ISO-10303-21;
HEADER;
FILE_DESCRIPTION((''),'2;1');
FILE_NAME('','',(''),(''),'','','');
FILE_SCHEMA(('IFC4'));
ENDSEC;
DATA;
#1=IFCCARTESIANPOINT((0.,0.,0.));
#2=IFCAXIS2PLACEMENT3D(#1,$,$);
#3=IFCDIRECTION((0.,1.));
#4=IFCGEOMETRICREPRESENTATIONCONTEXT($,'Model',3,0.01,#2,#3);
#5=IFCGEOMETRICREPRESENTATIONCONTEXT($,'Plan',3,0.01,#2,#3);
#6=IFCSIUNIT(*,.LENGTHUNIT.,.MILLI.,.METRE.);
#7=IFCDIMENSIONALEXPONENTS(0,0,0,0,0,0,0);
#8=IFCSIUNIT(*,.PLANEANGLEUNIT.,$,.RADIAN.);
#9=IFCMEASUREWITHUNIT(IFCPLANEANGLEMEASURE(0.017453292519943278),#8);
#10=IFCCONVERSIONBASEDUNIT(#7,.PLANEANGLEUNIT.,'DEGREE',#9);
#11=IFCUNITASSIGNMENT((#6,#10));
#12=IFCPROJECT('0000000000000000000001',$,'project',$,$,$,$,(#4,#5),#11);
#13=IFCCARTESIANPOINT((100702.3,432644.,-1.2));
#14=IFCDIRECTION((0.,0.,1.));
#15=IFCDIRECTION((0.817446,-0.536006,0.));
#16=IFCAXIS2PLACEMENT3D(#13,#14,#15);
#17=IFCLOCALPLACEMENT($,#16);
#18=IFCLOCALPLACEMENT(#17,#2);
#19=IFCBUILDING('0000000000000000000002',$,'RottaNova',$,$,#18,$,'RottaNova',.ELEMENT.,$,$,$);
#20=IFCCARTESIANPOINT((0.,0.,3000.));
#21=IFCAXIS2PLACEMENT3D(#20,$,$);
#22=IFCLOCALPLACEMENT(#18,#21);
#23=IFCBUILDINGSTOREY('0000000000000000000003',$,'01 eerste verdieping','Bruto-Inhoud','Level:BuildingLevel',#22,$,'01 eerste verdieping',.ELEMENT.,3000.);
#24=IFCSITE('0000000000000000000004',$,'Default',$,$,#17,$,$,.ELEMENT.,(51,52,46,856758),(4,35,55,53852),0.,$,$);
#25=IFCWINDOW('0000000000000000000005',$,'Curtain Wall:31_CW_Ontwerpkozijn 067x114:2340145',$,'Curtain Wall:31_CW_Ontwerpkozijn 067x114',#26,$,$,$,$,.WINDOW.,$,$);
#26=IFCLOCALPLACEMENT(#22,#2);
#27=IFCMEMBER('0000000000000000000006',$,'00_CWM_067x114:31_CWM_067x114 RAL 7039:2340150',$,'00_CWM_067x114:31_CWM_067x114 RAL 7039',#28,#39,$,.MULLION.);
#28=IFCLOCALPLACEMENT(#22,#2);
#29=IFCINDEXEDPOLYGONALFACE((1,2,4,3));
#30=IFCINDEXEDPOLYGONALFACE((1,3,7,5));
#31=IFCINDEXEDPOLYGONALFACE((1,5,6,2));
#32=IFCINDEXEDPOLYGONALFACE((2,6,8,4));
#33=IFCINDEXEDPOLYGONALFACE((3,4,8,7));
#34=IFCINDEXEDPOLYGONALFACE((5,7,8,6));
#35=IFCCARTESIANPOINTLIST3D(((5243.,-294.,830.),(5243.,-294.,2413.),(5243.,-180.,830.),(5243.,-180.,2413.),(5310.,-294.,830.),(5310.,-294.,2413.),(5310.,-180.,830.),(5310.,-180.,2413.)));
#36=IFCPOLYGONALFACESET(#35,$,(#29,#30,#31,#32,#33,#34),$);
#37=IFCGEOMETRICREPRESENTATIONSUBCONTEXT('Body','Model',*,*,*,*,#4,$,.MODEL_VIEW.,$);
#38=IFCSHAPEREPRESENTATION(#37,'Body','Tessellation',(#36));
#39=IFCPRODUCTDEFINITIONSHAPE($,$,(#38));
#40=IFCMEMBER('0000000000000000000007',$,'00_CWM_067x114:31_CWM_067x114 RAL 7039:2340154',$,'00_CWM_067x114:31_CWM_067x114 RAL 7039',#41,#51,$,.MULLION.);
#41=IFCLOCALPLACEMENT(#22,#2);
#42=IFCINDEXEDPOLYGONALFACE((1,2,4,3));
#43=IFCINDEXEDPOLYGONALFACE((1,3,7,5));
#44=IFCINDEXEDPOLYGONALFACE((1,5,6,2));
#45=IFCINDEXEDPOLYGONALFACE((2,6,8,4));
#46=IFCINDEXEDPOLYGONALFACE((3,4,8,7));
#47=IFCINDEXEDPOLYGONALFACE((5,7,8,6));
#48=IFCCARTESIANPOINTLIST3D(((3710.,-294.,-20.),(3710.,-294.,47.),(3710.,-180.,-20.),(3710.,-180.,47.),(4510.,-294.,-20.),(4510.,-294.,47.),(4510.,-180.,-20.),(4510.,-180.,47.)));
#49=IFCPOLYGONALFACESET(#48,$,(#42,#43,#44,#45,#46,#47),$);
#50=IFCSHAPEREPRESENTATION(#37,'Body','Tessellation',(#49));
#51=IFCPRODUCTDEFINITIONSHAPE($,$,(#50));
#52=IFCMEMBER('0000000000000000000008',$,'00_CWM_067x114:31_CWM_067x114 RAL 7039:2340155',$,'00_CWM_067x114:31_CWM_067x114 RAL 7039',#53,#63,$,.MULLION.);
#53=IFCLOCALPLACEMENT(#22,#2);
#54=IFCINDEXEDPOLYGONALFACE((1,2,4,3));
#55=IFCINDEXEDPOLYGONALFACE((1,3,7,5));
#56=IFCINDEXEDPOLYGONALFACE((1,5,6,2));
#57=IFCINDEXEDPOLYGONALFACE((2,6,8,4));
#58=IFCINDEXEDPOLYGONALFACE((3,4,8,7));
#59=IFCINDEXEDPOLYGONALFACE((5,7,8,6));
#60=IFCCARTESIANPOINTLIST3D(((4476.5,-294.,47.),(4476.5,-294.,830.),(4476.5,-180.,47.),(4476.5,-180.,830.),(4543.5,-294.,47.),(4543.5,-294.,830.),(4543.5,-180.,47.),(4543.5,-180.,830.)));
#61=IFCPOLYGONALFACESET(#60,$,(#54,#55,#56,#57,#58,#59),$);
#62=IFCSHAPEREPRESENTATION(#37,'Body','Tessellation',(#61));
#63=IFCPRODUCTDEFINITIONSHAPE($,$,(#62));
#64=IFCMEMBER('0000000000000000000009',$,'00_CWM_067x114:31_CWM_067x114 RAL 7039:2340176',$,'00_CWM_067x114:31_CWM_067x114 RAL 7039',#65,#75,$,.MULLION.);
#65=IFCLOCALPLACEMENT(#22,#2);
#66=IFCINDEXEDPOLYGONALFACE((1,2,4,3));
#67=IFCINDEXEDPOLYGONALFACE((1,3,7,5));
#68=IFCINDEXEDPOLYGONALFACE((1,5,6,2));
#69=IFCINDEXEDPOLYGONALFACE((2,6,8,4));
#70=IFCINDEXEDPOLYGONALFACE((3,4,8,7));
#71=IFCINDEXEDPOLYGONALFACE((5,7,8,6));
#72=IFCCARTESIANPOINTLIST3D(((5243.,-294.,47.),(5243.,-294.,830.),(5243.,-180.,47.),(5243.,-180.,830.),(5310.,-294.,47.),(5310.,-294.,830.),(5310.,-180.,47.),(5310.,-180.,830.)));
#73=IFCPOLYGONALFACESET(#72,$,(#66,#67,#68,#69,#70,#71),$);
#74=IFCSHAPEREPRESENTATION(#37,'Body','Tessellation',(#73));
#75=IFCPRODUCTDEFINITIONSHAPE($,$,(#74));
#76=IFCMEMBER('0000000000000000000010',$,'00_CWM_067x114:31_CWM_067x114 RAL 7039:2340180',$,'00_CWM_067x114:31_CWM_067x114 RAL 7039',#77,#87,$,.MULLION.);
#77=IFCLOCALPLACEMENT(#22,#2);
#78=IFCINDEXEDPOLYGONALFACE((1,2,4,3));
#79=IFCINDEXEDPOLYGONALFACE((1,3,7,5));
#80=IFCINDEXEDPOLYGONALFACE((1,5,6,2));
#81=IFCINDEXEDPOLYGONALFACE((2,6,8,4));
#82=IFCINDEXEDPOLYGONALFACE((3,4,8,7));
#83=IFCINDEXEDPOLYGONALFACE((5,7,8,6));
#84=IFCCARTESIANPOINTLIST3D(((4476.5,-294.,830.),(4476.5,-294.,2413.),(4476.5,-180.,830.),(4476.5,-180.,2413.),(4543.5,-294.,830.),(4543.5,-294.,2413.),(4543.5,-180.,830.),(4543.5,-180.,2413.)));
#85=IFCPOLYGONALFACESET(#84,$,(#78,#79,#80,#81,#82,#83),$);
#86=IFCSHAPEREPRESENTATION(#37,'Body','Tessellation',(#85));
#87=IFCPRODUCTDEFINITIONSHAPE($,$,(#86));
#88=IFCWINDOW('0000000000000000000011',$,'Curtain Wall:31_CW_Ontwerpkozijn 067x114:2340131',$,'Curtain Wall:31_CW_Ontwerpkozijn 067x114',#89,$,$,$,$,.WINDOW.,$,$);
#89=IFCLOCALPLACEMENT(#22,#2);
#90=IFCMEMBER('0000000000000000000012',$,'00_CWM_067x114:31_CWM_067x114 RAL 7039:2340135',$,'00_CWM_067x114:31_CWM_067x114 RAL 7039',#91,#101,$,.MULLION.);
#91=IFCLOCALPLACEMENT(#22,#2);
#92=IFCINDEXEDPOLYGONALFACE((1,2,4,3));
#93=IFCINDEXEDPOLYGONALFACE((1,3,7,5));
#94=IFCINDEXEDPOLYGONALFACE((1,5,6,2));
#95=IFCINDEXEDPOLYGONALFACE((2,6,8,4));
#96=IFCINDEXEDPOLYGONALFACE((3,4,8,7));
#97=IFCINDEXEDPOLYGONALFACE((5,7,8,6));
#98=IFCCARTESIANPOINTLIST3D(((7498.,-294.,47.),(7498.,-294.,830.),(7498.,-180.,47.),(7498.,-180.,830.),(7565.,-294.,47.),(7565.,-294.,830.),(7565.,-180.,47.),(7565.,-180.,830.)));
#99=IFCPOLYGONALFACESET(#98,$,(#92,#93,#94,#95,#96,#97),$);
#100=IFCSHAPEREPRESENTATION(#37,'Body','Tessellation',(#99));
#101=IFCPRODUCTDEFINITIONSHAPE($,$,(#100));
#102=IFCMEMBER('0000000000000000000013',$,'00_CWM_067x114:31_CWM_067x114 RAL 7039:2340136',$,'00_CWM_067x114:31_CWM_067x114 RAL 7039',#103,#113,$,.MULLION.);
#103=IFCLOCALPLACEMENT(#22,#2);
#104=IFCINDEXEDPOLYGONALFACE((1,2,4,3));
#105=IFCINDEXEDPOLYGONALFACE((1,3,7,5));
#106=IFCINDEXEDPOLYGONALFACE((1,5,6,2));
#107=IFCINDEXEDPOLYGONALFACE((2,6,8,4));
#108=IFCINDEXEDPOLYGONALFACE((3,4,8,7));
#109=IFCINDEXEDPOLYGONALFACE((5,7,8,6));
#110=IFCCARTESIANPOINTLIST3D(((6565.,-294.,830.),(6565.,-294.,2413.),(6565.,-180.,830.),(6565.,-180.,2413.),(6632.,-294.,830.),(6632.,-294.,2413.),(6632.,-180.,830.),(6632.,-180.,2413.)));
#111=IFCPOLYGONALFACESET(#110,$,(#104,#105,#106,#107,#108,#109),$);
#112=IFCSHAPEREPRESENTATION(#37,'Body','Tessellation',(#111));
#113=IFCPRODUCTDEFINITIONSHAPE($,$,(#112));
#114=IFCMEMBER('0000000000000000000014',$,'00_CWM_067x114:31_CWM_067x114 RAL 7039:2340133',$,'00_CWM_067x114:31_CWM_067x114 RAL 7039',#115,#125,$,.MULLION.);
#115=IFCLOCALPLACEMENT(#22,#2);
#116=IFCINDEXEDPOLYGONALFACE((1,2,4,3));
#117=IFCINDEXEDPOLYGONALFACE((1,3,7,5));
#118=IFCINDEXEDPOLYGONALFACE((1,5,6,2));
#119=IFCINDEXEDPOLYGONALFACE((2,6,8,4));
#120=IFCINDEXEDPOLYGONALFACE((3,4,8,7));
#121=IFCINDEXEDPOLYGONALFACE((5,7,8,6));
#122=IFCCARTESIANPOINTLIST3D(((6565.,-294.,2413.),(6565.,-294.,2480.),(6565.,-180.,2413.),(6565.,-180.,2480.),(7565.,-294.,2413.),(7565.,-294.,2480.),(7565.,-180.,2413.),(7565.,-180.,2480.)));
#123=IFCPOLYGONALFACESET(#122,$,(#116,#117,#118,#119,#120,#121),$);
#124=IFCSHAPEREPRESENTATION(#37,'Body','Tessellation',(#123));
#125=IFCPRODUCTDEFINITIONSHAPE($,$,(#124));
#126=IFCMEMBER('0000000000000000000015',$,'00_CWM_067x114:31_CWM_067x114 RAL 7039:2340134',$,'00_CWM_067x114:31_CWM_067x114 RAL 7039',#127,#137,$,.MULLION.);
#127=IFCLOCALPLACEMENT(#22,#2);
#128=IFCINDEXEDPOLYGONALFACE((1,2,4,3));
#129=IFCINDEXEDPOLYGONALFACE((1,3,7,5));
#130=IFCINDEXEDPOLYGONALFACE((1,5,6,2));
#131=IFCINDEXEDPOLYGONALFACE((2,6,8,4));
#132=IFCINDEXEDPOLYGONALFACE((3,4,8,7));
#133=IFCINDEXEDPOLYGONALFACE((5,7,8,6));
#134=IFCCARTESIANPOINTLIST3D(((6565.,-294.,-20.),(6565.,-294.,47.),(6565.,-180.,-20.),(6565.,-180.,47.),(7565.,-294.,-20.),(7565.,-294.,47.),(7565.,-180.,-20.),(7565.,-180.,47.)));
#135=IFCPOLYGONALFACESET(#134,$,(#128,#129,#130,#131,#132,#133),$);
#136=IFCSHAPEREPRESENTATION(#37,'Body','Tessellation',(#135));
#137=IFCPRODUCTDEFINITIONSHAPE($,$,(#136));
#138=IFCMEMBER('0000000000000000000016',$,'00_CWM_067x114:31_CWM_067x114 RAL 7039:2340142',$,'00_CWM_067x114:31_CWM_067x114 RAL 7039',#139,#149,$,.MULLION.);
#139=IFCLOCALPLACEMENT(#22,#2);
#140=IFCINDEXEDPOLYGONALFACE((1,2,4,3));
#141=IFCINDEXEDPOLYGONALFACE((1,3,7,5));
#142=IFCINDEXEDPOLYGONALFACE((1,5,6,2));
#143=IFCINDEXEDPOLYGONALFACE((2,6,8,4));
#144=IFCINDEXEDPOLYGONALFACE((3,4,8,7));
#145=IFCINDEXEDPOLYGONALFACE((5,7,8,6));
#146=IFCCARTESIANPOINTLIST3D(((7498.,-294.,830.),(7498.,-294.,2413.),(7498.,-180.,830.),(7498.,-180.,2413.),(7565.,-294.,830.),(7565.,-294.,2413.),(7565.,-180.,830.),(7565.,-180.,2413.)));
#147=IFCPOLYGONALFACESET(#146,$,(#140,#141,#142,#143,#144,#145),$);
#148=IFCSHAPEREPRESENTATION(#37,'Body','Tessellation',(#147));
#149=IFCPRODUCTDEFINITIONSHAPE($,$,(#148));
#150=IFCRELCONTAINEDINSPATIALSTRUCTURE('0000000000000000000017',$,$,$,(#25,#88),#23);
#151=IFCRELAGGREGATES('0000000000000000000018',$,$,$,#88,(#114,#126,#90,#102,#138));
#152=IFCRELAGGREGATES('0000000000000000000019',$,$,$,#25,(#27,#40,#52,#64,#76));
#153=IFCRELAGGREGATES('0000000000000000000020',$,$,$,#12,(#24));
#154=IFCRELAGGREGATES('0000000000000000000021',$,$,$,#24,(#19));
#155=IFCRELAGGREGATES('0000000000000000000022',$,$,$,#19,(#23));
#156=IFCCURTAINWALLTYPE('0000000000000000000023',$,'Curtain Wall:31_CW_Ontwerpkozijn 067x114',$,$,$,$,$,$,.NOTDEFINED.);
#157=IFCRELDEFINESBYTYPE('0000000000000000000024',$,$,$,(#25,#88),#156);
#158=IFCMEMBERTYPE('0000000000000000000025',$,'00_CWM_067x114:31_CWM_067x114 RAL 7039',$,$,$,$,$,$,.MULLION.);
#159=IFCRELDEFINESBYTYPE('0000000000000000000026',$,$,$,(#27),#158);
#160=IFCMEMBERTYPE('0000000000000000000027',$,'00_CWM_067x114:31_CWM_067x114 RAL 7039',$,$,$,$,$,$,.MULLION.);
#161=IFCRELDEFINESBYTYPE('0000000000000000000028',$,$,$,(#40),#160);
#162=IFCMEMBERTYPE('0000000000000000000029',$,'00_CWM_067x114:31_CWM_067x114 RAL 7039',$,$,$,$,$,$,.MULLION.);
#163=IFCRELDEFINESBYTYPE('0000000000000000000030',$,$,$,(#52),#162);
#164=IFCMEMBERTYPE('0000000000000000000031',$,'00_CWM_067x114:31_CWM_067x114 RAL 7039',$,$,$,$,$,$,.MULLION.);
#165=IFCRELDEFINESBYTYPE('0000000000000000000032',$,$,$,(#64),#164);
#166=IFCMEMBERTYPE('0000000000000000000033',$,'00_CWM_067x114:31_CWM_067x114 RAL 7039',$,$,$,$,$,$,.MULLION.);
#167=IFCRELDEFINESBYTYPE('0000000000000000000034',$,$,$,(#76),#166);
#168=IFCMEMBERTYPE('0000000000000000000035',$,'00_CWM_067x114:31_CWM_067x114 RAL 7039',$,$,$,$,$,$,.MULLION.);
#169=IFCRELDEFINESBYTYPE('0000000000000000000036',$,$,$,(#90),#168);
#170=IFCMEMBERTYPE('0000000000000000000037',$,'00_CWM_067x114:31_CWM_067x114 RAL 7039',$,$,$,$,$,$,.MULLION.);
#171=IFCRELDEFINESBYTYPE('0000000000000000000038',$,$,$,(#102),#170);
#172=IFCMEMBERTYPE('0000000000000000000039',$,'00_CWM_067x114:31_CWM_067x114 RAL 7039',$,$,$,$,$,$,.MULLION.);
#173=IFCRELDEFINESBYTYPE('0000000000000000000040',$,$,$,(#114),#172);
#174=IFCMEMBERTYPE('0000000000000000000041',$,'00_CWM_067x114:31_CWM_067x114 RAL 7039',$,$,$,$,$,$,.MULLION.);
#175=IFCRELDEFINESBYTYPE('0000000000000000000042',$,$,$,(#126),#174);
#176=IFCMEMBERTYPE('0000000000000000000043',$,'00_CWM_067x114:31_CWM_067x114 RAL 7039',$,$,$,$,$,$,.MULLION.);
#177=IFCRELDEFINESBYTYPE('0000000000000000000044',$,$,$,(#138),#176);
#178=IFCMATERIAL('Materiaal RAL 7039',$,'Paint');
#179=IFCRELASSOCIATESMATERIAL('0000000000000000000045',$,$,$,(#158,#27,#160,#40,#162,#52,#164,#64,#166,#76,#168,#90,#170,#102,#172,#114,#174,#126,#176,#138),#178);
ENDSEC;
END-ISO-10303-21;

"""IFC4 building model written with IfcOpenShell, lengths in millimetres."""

from ifc_helpers import new_model, entity, si_unit, converted_unit, direction, frame, origin, place, context, subcontext, project, spatial, indexed_curve, outline, extrude, source, transform, mapped, material, type_object, type_shapes, element, aggregate, save


model = new_model("IFC4")

# Units and contexts
model_context = context("Model", 3, precision=0.01, world=origin(), true_north=direction((0.0, 1.0)))
plan_context = context("Plan", 3, precision=0.01, world=origin(), true_north=direction((0.0, 1.0)))
body_context = subcontext(model_context, "Body", "Model", "MODEL_VIEW")
ifc_project = project(units=[si_unit("LENGTHUNIT", "METRE", prefix="MILLI"), converted_unit("PLANEANGLEUNIT", "DEGREE", entity("IfcPlaneAngleMeasure", 0.017453292519943278), si_unit("PLANEANGLEUNIT", "RADIAN"), dimensions=[0, 0, 0, 0, 0, 0, 0])], contexts=[model_context, plan_context])

# Site, building, storey
site_placement = place(None, frame((100702.3, 432644.0, -1.2), z_axis=(0.0, 0.0, 1.0), x_axis=(0.817446, -0.536006, 0.0)))
site = spatial("IfcSite", under=ifc_project, at=site_placement, Name="Default", CompositionType="ELEMENT", RefLatitude=(51, 52, 46, 856758), RefLongitude=(4, 35, 55, 53852), RefElevation=0.0)
building_placement = place(site_placement, origin())
building = spatial("IfcBuilding", under=site, at=building_placement, Name="RottaNova", LongName="RottaNova", CompositionType="ELEMENT")
storey_placement = place(building_placement, frame((0.0, 0.0, 3000.0)))
storey = spatial("IfcBuildingStorey", under=building, at=storey_placement, Name="01 eerste verdieping", Description="Bruto-Inhoud", ObjectType="Level:BuildingLevel", LongName="01 eerste verdieping", CompositionType="ELEMENT", Elevation=3000.0)

# Windows, members
curtain_wall_type = type_object("IfcCurtainWallType", Name="Curtain Wall:31_CW_Ontwerpkozijn 067x114", PredefinedType="NOTDEFINED")
window_1_placement = place(storey_placement, frame((0.0, 0.0, -3000.0)))
window_1 = element("IfcWindow", 1, at=window_1_placement, inside=storey, type_object=curtain_wall_type, Name="Curtain Wall:31_CW_Ontwerpkozijn 067x114:2340145", ObjectType="Curtain Wall:31_CW_Ontwerpkozijn 067x114", PredefinedType="WINDOW")
ifc_material_1 = material(Name="Materiaal RAL 7039", Category="Paint")
member_type_1 = type_object("IfcMemberType", Name="00_CWM_067x114:31_CWM_067x114 RAL 7039", PredefinedType="MULLION", material=ifc_material_1)
shared_shape_1 = source(origin(), body_context, "Body", "SweptSolid", [
    extrude(outline(indexed_curve([(-33.5, -57.0), (33.5, -57.0), (33.5, 57.0), (-33.5, 57.0), (-33.5, -57.0)], self_intersect=False)), frame((-33.5, -57.0, -1583.0), z_axis=(0.0, 0.0, 1.0), x_axis=(-1.0, 0.0, 0.0)), (0.0, 0.0, 1.0), 1583.0),
])
type_shapes(member_type_1, [shared_shape_1])
member_1_placement = place(window_1_placement, frame((5310.0, -180.0, 5413.0)))
member_1 = element("IfcMember", 2, at=member_1_placement, type_object=member_type_1, material=ifc_material_1, Name="00_CWM_067x114:31_CWM_067x114 RAL 7039:2340150", ObjectType="00_CWM_067x114:31_CWM_067x114 RAL 7039", PredefinedType="MULLION", context=body_context, shape_type="MappedRepresentation", body=[
    mapped(shared_shape_1, transform((0.0, 0.0, 0.0), scale=1.0)),
])
member_type_2 = type_object("IfcMemberType", Name="00_CWM_067x114:31_CWM_067x114 RAL 7039", PredefinedType="MULLION", material=ifc_material_1)
shared_shape_2 = source(origin(), body_context, "Body", "SweptSolid", [
    extrude(outline(indexed_curve([(-33.5, -57.0), (33.5, -57.0), (33.5, 57.0), (-33.5, 57.0), (-33.5, -57.0)], self_intersect=False)), frame((-33.5, -57.0, -800.0), z_axis=(0.0, 0.0, 1.0), x_axis=(-1.0, 0.0, 0.0)), (0.0, 0.0, 1.0), 800.0),
])
type_shapes(member_type_2, [shared_shape_2])
member_2_placement = place(window_1_placement, frame((4510.0, -180.0, 2980.0), z_axis=(1.0, 0.0, 0.0), x_axis=(0.0, 0.0, -1.0)))
member_2 = element("IfcMember", 3, at=member_2_placement, type_object=member_type_2, material=ifc_material_1, Name="00_CWM_067x114:31_CWM_067x114 RAL 7039:2340154", ObjectType="00_CWM_067x114:31_CWM_067x114 RAL 7039", PredefinedType="MULLION", context=body_context, shape_type="MappedRepresentation", body=[
    mapped(shared_shape_2, transform((0.0, 0.0, 0.0), scale=1.0)),
])
member_type_3 = type_object("IfcMemberType", Name="00_CWM_067x114:31_CWM_067x114 RAL 7039", PredefinedType="MULLION", material=ifc_material_1)
shared_shape_3 = source(origin(), body_context, "Body", "SweptSolid", [
    extrude(outline(indexed_curve([(-33.5, -57.0), (33.5, -57.0), (33.5, 57.0), (-33.5, 57.0), (-33.5, -57.0)], self_intersect=False)), frame((0.0, -57.0, -783.0), z_axis=(0.0, 0.0, 1.0), x_axis=(-1.0, 0.0, 0.0)), (0.0, 0.0, 1.0), 783.0),
])
type_shapes(member_type_3, [shared_shape_3])
member_3_placement = place(window_1_placement, frame((4510.0, -180.0, 3047.0), z_axis=(0.0, 0.0, -1.0), x_axis=(-1.0, 0.0, 0.0)))
member_3 = element("IfcMember", 4, at=member_3_placement, type_object=member_type_3, material=ifc_material_1, Name="00_CWM_067x114:31_CWM_067x114 RAL 7039:2340155", ObjectType="00_CWM_067x114:31_CWM_067x114 RAL 7039", PredefinedType="MULLION", context=body_context, shape_type="MappedRepresentation", body=[
    mapped(shared_shape_3, transform((0.0, 0.0, 0.0), scale=1.0)),
])
member_type_4 = type_object("IfcMemberType", Name="00_CWM_067x114:31_CWM_067x114 RAL 7039", PredefinedType="MULLION", material=ifc_material_1)
shared_shape_4 = source(origin(), body_context, "Body", "SweptSolid", [
    extrude(outline(indexed_curve([(-33.5, -57.0), (33.5, -57.0), (33.5, 57.0), (-33.5, 57.0), (-33.5, -57.0)], self_intersect=False)), frame((-33.5, -57.0, -783.0), z_axis=(0.0, 0.0, 1.0), x_axis=(-1.0, 0.0, 0.0)), (0.0, 0.0, 1.0), 783.0),
])
type_shapes(member_type_4, [shared_shape_4])
member_4_placement = place(window_1_placement, frame((5310.0, -180.0, 3830.0)))
member_4 = element("IfcMember", 5, at=member_4_placement, type_object=member_type_4, material=ifc_material_1, Name="00_CWM_067x114:31_CWM_067x114 RAL 7039:2340176", ObjectType="00_CWM_067x114:31_CWM_067x114 RAL 7039", PredefinedType="MULLION", context=body_context, shape_type="MappedRepresentation", body=[
    mapped(shared_shape_4, transform((0.0, 0.0, 0.0), scale=1.0)),
])
member_type_5 = type_object("IfcMemberType", Name="00_CWM_067x114:31_CWM_067x114 RAL 7039", PredefinedType="MULLION", material=ifc_material_1)
shared_shape_5 = source(origin(), body_context, "Body", "SweptSolid", [
    extrude(outline(indexed_curve([(-33.5, -57.0), (33.5, -57.0), (33.5, 57.0), (-33.5, 57.0), (-33.5, -57.0)], self_intersect=False)), frame((0.0, -57.0, -1583.0), z_axis=(0.0, 0.0, 1.0), x_axis=(-1.0, 0.0, 0.0)), (0.0, 0.0, 1.0), 1583.0),
])
type_shapes(member_type_5, [shared_shape_5])
member_5_placement = place(window_1_placement, frame((4510.0, -180.0, 3830.0), z_axis=(0.0, 0.0, -1.0), x_axis=(-1.0, 0.0, 0.0)))
member_5 = element("IfcMember", 6, at=member_5_placement, type_object=member_type_5, material=ifc_material_1, Name="00_CWM_067x114:31_CWM_067x114 RAL 7039:2340180", ObjectType="00_CWM_067x114:31_CWM_067x114 RAL 7039", PredefinedType="MULLION", context=body_context, shape_type="MappedRepresentation", body=[
    mapped(shared_shape_5, transform((0.0, 0.0, 0.0), scale=1.0)),
])
window_2_placement = place(storey_placement, frame((0.0, 0.0, -3000.0)))
window_2 = element("IfcWindow", 7, at=window_2_placement, inside=storey, type_object=curtain_wall_type, Name="Curtain Wall:31_CW_Ontwerpkozijn 067x114:2340131", ObjectType="Curtain Wall:31_CW_Ontwerpkozijn 067x114", PredefinedType="WINDOW")
member_type_6 = type_object("IfcMemberType", Name="00_CWM_067x114:31_CWM_067x114 RAL 7039", PredefinedType="MULLION", material=ifc_material_1)
shared_shape_6 = source(origin(), body_context, "Body", "SweptSolid", [
    extrude(outline(indexed_curve([(-33.5, -57.0), (33.5, -57.0), (33.5, 57.0), (-33.5, 57.0), (-33.5, -57.0)], self_intersect=False)), frame((-33.5, 57.0, -783.0), z_axis=(0.0, 0.0, 1.0), x_axis=(-1.0, 0.0, 0.0)), (0.0, 0.0, 1.0), 783.0),
])
type_shapes(member_type_6, [shared_shape_6])
member_6_placement = place(window_2_placement, frame((7565.0, -180.0, 3047.0), z_axis=(0.0, 0.0, -1.0), x_axis=(1.0, 0.0, 0.0)))
member_6 = element("IfcMember", 8, at=member_6_placement, type_object=member_type_6, material=ifc_material_1, Name="00_CWM_067x114:31_CWM_067x114 RAL 7039:2340135", ObjectType="00_CWM_067x114:31_CWM_067x114 RAL 7039", PredefinedType="MULLION", context=body_context, shape_type="MappedRepresentation", body=[
    mapped(shared_shape_6, transform((0.0, 0.0, 0.0), scale=1.0)),
])
member_type_7 = type_object("IfcMemberType", Name="00_CWM_067x114:31_CWM_067x114 RAL 7039", PredefinedType="MULLION", material=ifc_material_1)
shared_shape_7 = source(origin(), body_context, "Body", "SweptSolid", [
    extrude(outline(indexed_curve([(-33.5, -57.0), (33.5, -57.0), (33.5, 57.0), (-33.5, 57.0), (-33.5, -57.0)], self_intersect=False)), frame((-33.5, 57.0, -1583.0), z_axis=(0.0, 0.0, 1.0), x_axis=(-1.0, 0.0, 0.0)), (0.0, 0.0, 1.0), 1583.0),
])
type_shapes(member_type_7, [shared_shape_7])
member_7_placement = place(window_2_placement, frame((6565.0, -180.0, 5413.0), z_axis=(0.0, 0.0, 1.0), x_axis=(-1.0, 0.0, 0.0)))
member_7 = element("IfcMember", 9, at=member_7_placement, type_object=member_type_7, material=ifc_material_1, Name="00_CWM_067x114:31_CWM_067x114 RAL 7039:2340136", ObjectType="00_CWM_067x114:31_CWM_067x114 RAL 7039", PredefinedType="MULLION", context=body_context, shape_type="MappedRepresentation", body=[
    mapped(shared_shape_7, transform((0.0, 0.0, 0.0), scale=1.0)),
])
member_type_8 = type_object("IfcMemberType", Name="00_CWM_067x114:31_CWM_067x114 RAL 7039", PredefinedType="MULLION", material=ifc_material_1)
shared_shape_8 = source(origin(), body_context, "Body", "SweptSolid", [
    extrude(outline(indexed_curve([(-33.5, -57.0), (33.5, -57.0), (33.5, 57.0), (-33.5, 57.0), (-33.5, -57.0)], self_intersect=False)), frame((-33.5, 57.0, -1000.0), z_axis=(0.0, 0.0, 1.0), x_axis=(-1.0, 0.0, 0.0)), (0.0, 0.0, 1.0), 1000.0),
])
type_shapes(member_type_8, [shared_shape_8])
member_8_placement = place(window_2_placement, frame((7565.0, -180.0, 5480.0), z_axis=(1.0, 0.0, 0.0), x_axis=(0.0, 0.0, 1.0)))
member_8 = element("IfcMember", 10, at=member_8_placement, type_object=member_type_8, material=ifc_material_1, Name="00_CWM_067x114:31_CWM_067x114 RAL 7039:2340133", ObjectType="00_CWM_067x114:31_CWM_067x114 RAL 7039", PredefinedType="MULLION", context=body_context, shape_type="MappedRepresentation", body=[
    mapped(shared_shape_8, transform((0.0, 0.0, 0.0), scale=1.0)),
])
member_type_9 = type_object("IfcMemberType", Name="00_CWM_067x114:31_CWM_067x114 RAL 7039", PredefinedType="MULLION", material=ifc_material_1)
shared_shape_9 = source(origin(), body_context, "Body", "SweptSolid", [
    extrude(outline(indexed_curve([(-33.5, -57.0), (33.5, -57.0), (33.5, 57.0), (-33.5, 57.0), (-33.5, -57.0)], self_intersect=False)), frame((-33.5, 57.0, -1000.0), z_axis=(0.0, 0.0, 1.0), x_axis=(-1.0, 0.0, 0.0)), (0.0, 0.0, 1.0), 1000.0),
])
type_shapes(member_type_9, [shared_shape_9])
member_9_placement = place(window_2_placement, frame((6565.0, -180.0, 2980.0), z_axis=(-1.0, 0.0, 0.0), x_axis=(0.0, 0.0, -1.0)))
member_9 = element("IfcMember", 11, at=member_9_placement, type_object=member_type_9, material=ifc_material_1, Name="00_CWM_067x114:31_CWM_067x114 RAL 7039:2340134", ObjectType="00_CWM_067x114:31_CWM_067x114 RAL 7039", PredefinedType="MULLION", context=body_context, shape_type="MappedRepresentation", body=[
    mapped(shared_shape_9, transform((0.0, 0.0, 0.0), scale=1.0)),
])
member_type_10 = type_object("IfcMemberType", Name="00_CWM_067x114:31_CWM_067x114 RAL 7039", PredefinedType="MULLION", material=ifc_material_1)
shared_shape_10 = source(origin(), body_context, "Body", "SweptSolid", [
    extrude(outline(indexed_curve([(-33.5, -57.0), (33.5, -57.0), (33.5, 57.0), (-33.5, 57.0), (-33.5, -57.0)], self_intersect=False)), frame((-33.5, 57.0, -1583.0), z_axis=(0.0, 0.0, 1.0), x_axis=(-1.0, 0.0, 0.0)), (0.0, 0.0, 1.0), 1583.0),
])
type_shapes(member_type_10, [shared_shape_10])
member_10_placement = place(window_2_placement, frame((7565.0, -180.0, 3830.0), z_axis=(0.0, 0.0, -1.0), x_axis=(1.0, 0.0, 0.0)))
member_10 = element("IfcMember", 12, at=member_10_placement, type_object=member_type_10, material=ifc_material_1, Name="00_CWM_067x114:31_CWM_067x114 RAL 7039:2340142", ObjectType="00_CWM_067x114:31_CWM_067x114 RAL 7039", PredefinedType="MULLION", context=body_context, shape_type="MappedRepresentation", body=[
    mapped(shared_shape_10, transform((0.0, 0.0, 0.0), scale=1.0)),
])

aggregate(window_2, [member_8, member_9, member_6, member_7, member_10])
aggregate(window_1, [member_1, member_2, member_3, member_4, member_5])

save(model, "model.ifc")
